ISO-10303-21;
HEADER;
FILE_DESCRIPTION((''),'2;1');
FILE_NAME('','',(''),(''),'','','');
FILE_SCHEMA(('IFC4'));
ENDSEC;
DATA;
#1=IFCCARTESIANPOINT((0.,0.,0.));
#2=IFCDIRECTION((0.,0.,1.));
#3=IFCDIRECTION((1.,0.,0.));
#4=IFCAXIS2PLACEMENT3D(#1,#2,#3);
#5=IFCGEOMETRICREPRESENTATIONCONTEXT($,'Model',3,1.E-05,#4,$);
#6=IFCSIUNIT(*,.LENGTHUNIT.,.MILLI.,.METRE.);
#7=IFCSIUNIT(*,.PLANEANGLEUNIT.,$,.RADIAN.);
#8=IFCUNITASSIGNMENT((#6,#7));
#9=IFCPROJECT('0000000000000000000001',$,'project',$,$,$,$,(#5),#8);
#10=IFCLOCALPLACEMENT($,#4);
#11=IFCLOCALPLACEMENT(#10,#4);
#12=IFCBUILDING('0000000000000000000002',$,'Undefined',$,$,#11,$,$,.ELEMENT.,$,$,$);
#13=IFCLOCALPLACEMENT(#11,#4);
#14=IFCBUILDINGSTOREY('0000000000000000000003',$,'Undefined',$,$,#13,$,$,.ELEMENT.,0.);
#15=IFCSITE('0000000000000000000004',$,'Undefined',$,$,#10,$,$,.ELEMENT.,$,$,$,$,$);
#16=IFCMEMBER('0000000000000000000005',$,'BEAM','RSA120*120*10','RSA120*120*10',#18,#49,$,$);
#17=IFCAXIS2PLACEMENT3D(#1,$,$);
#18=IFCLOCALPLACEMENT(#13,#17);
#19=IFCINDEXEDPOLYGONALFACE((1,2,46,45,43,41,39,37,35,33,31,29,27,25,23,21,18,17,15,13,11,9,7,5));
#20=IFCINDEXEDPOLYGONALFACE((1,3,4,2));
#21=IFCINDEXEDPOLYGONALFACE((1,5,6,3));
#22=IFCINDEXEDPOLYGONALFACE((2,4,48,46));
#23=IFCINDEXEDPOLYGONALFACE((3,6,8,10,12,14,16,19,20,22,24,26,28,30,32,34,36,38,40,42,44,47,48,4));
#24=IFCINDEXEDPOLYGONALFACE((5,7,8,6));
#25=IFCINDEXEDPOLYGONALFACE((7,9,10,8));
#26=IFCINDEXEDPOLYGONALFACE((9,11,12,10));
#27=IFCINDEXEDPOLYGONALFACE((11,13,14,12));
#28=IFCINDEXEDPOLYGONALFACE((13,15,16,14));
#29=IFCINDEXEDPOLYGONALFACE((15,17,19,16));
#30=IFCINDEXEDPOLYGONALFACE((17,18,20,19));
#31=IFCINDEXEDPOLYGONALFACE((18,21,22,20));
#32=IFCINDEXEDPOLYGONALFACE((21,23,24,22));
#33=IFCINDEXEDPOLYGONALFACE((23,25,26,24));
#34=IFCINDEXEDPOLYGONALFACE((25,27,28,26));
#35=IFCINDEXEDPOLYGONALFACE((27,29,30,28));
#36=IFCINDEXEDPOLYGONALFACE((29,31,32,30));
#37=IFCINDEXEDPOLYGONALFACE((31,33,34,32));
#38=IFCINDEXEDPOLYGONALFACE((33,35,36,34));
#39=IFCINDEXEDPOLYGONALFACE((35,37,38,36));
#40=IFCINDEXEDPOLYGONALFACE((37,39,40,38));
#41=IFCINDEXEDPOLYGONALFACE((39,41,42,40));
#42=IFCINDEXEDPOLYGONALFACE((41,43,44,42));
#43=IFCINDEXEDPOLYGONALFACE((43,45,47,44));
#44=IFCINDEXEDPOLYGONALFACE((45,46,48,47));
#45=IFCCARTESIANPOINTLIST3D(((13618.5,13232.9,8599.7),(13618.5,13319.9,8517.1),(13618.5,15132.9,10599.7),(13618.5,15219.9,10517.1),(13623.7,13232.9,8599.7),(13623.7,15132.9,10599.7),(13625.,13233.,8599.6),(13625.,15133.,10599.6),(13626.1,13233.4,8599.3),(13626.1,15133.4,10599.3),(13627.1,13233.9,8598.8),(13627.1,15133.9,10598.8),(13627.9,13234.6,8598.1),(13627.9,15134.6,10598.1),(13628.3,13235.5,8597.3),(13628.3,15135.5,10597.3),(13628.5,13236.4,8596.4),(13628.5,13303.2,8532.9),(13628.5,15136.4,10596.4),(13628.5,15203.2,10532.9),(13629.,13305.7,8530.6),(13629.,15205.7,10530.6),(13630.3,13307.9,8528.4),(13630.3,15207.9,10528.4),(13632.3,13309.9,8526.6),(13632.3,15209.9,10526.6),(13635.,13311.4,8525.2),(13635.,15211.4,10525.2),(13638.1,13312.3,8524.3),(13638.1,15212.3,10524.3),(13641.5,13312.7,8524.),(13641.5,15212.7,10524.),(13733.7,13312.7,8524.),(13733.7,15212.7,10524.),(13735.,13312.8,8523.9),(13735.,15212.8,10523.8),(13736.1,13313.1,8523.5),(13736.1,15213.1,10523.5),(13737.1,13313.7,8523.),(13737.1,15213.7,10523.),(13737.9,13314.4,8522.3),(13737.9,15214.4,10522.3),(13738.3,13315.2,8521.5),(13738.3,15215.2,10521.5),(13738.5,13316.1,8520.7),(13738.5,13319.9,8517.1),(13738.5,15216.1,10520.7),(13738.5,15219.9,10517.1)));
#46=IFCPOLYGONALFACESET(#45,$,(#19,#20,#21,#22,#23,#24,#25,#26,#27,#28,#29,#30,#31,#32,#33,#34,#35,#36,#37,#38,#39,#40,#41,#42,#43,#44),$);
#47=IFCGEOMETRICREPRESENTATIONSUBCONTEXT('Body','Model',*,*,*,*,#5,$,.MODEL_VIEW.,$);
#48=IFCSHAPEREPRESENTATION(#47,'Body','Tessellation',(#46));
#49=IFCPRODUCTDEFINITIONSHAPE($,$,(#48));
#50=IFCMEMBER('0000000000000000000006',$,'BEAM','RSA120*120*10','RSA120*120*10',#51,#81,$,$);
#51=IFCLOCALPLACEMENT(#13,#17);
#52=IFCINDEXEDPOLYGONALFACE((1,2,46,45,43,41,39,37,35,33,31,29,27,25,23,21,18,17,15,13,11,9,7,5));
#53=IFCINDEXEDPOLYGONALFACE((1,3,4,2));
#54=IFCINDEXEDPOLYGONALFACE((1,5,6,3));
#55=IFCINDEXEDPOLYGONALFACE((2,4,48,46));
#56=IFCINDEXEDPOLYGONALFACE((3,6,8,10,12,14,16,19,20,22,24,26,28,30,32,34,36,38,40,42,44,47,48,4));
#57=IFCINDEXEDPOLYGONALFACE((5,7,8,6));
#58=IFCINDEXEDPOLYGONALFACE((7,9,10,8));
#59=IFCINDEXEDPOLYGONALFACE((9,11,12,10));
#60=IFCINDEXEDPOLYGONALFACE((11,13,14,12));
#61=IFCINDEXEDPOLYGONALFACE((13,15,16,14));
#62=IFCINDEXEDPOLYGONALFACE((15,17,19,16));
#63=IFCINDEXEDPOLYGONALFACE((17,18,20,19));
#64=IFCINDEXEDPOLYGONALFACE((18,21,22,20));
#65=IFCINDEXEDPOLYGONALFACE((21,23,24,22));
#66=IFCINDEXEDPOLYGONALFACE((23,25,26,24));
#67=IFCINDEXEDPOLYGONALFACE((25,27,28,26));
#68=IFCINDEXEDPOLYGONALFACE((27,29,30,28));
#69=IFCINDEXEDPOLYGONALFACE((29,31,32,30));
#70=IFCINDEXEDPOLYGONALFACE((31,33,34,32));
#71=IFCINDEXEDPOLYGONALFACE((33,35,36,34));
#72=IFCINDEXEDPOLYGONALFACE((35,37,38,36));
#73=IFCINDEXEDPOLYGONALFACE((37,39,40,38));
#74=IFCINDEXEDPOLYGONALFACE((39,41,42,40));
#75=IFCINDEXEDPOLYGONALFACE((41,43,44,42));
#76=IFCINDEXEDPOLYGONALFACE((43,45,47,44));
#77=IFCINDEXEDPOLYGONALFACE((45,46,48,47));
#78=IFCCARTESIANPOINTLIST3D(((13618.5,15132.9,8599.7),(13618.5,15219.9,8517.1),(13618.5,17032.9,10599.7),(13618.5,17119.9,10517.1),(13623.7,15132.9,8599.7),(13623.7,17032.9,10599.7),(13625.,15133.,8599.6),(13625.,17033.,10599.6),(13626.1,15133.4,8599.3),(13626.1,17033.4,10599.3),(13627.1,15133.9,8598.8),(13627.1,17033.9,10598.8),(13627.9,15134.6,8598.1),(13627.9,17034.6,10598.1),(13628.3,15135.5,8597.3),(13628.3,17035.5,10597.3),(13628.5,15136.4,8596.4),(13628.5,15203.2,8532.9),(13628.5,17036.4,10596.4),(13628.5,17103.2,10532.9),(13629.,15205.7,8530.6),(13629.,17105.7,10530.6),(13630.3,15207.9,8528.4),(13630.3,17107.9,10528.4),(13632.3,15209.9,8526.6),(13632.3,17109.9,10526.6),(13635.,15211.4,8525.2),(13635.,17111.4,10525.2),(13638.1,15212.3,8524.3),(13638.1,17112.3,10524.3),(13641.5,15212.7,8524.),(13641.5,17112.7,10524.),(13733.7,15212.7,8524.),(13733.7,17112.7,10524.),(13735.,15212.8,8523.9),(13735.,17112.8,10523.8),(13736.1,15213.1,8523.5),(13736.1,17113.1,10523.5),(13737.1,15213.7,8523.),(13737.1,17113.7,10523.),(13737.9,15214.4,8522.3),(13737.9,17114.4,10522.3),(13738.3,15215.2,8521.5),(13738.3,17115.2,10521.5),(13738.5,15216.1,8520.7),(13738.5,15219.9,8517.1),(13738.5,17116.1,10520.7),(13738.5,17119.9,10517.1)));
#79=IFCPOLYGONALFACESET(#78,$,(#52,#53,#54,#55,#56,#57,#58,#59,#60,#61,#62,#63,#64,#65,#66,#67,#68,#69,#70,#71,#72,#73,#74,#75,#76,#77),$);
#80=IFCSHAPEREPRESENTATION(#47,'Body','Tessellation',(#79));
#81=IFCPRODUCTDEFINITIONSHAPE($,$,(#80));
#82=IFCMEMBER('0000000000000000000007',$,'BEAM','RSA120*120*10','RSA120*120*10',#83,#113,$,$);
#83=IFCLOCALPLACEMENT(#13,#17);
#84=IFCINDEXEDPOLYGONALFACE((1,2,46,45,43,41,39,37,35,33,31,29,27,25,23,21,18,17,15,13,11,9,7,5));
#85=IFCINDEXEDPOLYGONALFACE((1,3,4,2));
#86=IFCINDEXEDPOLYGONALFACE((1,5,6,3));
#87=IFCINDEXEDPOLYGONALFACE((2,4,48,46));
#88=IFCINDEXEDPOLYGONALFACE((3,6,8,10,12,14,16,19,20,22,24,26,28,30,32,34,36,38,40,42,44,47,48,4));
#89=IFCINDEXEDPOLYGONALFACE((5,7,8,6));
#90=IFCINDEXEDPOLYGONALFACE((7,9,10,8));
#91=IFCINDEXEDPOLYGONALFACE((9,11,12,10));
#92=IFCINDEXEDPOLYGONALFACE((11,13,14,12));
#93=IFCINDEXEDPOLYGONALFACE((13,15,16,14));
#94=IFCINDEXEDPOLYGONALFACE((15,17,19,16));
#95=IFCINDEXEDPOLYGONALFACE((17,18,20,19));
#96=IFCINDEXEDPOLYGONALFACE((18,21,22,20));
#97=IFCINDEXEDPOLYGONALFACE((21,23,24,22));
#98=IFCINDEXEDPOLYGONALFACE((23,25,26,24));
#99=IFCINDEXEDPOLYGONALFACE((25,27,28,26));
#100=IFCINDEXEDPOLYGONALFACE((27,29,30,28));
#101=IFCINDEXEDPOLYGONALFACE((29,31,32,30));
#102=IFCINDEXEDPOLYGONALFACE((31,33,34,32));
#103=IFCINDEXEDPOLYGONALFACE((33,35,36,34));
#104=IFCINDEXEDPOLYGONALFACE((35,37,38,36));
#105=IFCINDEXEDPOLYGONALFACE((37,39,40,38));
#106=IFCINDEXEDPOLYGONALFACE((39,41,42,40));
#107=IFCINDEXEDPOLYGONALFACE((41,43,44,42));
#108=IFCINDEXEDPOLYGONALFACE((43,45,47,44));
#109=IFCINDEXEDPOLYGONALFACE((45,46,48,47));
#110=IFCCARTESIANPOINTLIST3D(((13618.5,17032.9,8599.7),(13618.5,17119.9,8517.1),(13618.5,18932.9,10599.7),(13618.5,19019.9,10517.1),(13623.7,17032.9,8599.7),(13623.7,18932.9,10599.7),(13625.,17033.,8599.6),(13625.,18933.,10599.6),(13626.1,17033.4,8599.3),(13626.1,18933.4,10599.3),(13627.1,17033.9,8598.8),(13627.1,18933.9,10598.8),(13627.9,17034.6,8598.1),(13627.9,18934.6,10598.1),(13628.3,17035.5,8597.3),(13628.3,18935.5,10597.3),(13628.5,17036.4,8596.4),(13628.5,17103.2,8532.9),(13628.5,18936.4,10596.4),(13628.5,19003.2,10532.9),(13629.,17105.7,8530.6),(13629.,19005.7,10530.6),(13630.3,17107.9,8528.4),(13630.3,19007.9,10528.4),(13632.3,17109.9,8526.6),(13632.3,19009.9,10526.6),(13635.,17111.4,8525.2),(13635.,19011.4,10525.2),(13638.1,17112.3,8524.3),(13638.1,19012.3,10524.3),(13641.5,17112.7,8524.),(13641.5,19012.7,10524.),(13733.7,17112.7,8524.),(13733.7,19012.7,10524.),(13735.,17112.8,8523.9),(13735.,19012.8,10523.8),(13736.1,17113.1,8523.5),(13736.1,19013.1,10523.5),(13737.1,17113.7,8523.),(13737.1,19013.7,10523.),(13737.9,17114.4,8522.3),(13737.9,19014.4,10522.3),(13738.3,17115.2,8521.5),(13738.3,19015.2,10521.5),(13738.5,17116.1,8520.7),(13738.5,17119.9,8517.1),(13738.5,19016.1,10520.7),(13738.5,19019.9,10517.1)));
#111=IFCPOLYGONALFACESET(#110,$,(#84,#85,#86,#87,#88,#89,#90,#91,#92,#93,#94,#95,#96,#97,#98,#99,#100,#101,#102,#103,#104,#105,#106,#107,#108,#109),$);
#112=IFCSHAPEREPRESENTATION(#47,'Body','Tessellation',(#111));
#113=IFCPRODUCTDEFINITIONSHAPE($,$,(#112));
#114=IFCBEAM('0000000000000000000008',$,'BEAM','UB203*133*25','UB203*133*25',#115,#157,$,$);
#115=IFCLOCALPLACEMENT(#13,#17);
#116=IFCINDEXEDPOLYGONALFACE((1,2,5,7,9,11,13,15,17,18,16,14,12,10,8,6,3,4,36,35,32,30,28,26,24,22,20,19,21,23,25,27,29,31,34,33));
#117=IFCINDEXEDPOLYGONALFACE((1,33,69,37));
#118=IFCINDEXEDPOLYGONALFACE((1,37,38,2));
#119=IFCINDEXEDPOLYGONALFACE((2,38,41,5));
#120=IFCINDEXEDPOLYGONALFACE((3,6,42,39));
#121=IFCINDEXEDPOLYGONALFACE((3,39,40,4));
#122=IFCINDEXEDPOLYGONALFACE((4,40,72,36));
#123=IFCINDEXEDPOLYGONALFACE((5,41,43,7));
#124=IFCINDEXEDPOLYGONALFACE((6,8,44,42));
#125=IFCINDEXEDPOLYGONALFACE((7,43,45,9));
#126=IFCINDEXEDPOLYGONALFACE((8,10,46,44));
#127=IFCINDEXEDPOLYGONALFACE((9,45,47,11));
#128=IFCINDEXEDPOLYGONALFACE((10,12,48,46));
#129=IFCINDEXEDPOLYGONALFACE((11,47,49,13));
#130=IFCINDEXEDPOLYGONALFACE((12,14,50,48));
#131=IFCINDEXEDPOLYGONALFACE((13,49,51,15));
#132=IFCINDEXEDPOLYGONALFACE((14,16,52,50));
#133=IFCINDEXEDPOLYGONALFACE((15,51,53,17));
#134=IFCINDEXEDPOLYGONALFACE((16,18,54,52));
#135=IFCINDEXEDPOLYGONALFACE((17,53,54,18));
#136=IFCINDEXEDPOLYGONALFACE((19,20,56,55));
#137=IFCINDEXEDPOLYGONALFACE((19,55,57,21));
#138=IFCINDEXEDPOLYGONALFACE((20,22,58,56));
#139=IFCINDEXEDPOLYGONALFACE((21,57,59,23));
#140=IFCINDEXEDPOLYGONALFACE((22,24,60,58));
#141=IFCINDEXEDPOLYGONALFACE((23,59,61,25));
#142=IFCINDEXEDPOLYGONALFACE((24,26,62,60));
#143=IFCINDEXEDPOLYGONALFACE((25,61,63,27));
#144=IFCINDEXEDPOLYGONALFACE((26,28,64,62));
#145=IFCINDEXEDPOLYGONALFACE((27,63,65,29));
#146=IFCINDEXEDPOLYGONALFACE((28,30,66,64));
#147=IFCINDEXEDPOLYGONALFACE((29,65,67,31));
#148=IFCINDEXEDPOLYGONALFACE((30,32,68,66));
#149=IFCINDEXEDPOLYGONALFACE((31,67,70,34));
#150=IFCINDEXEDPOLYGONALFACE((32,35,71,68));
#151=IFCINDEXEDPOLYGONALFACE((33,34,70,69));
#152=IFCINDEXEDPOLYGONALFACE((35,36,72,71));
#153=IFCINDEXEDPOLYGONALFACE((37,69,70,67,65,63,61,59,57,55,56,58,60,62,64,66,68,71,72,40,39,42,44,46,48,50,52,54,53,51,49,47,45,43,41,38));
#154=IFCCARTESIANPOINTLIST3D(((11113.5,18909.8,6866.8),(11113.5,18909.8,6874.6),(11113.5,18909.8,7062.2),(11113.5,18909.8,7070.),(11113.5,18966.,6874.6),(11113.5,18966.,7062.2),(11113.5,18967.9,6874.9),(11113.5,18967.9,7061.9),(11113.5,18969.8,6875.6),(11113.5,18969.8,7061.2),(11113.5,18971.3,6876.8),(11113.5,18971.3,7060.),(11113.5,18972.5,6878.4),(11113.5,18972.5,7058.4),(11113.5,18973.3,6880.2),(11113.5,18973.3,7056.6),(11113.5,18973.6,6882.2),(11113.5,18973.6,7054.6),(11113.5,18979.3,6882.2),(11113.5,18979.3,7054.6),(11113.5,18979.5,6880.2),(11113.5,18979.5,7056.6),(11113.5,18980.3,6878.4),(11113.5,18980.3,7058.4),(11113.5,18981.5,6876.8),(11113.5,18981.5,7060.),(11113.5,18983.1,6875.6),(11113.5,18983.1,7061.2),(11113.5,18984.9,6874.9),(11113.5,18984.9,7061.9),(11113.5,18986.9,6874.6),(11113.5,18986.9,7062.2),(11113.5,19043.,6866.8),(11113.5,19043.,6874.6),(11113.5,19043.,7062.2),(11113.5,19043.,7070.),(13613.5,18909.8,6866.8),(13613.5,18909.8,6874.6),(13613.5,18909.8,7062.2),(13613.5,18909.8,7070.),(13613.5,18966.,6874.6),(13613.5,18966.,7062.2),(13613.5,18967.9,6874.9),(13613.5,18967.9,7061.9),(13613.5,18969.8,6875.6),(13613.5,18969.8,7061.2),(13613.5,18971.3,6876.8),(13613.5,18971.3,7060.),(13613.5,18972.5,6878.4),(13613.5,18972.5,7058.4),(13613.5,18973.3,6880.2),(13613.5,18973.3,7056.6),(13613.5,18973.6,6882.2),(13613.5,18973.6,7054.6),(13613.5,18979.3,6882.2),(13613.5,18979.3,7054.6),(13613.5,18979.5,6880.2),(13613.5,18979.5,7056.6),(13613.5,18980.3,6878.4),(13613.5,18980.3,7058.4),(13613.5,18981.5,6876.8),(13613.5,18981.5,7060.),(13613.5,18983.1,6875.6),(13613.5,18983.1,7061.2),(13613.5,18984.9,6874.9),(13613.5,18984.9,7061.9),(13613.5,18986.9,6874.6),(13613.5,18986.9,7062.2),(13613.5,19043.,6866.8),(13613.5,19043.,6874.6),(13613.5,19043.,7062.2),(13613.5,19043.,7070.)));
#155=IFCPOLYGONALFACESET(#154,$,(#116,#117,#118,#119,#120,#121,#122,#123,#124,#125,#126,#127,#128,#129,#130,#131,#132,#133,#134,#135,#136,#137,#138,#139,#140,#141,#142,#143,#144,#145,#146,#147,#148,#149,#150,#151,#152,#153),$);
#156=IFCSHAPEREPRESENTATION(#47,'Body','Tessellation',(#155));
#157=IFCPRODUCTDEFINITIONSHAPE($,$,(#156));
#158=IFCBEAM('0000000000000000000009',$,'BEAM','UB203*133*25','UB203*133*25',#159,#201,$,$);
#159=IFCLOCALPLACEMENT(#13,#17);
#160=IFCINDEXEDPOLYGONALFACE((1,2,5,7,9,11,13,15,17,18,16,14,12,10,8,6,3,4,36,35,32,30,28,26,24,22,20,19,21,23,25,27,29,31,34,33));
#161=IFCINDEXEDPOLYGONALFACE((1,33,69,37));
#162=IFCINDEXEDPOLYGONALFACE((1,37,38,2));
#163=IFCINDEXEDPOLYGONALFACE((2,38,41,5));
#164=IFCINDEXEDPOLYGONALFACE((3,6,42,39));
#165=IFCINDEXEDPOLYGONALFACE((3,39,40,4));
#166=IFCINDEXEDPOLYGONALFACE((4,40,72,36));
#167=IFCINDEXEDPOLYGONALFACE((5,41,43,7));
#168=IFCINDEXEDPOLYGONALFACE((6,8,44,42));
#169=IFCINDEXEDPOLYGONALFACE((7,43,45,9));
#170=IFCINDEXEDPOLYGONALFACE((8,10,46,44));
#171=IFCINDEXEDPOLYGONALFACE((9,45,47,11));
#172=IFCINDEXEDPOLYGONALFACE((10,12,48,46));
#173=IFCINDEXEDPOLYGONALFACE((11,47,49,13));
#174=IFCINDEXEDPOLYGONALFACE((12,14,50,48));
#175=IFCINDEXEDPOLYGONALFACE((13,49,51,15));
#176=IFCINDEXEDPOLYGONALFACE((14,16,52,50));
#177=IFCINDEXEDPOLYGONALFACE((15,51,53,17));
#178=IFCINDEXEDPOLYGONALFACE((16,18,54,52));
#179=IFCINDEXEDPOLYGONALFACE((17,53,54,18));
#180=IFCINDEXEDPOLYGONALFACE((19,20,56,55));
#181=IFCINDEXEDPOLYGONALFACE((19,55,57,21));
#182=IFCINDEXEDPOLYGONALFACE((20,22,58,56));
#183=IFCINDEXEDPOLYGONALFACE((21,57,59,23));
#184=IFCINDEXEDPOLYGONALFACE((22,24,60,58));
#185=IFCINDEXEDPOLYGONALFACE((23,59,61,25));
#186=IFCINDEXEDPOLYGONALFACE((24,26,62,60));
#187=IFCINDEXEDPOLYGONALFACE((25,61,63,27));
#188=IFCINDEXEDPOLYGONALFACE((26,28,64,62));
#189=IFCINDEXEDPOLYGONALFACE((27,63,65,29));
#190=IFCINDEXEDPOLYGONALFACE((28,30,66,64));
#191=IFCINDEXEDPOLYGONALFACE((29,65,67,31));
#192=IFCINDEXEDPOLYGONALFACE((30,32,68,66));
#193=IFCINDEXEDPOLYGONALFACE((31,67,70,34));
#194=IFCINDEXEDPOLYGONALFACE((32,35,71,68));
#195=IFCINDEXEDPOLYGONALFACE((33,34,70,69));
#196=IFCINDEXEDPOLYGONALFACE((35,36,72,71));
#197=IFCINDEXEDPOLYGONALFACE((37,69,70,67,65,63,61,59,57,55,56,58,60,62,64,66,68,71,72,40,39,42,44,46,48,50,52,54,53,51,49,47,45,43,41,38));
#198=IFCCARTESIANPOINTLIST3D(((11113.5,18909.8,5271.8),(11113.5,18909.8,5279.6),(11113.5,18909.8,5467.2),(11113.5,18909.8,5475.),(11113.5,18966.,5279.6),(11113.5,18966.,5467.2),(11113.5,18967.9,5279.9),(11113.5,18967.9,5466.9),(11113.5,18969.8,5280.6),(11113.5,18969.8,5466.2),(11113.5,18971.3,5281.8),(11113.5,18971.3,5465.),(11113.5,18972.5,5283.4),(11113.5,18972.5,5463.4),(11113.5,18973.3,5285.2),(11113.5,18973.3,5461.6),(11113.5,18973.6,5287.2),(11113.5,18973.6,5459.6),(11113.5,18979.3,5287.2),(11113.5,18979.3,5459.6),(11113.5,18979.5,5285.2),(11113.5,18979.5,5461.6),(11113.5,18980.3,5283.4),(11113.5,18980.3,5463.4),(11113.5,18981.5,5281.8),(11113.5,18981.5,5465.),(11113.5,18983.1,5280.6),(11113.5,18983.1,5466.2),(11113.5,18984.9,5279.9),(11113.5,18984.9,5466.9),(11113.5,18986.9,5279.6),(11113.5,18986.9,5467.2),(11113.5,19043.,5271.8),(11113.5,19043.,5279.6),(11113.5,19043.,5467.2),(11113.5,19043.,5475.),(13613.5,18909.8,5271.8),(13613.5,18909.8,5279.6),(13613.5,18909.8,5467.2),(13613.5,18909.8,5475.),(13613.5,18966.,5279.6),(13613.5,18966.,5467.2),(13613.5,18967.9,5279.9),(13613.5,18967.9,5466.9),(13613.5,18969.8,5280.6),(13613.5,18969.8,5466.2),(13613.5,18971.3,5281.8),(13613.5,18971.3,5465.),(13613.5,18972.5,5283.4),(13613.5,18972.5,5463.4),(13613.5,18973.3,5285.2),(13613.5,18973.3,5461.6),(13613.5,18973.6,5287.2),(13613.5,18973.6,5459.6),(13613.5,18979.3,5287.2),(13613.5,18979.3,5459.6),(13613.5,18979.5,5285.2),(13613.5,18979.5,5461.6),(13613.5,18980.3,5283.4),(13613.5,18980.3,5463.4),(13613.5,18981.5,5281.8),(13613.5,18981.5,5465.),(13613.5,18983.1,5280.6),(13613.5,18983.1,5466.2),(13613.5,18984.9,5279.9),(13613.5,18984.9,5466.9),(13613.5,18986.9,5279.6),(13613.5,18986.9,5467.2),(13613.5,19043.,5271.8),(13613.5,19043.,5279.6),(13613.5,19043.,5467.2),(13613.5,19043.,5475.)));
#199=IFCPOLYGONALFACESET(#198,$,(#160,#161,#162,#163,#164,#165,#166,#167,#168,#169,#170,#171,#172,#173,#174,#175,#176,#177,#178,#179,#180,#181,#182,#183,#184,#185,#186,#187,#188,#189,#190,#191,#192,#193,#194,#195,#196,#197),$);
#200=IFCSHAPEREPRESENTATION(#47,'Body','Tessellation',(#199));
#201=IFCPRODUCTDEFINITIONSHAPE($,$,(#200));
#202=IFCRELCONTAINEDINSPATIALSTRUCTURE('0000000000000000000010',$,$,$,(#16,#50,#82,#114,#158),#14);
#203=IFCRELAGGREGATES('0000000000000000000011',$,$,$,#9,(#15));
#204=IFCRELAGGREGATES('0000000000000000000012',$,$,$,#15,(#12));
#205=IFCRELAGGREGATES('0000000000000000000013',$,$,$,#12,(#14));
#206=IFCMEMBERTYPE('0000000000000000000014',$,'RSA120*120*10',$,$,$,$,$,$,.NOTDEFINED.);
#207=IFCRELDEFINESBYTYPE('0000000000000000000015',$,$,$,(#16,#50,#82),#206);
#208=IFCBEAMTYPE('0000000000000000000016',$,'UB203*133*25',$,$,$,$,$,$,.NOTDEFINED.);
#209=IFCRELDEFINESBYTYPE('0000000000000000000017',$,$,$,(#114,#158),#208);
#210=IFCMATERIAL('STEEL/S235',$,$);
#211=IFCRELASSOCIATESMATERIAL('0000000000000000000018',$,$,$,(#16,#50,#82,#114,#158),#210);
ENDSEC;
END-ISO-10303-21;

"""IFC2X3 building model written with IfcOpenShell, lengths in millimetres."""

from ifc_helpers import new_model, si_unit, frame, origin_with_axes, origin_2d_with_axis, place, context, subcontext, project, spatial, i_section, l_section, extrude, material, type_object, element, save


model = new_model("IFC2X3")

# Units and contexts
model_context = context("Model", 3, precision=1e-05, world=origin_with_axes())
body_context = subcontext(model_context, "Body", "Model", "MODEL_VIEW")
ifc_project = project(units=[si_unit("LENGTHUNIT", "METRE", prefix="MILLI"), si_unit("PLANEANGLEUNIT", "RADIAN")], contexts=[model_context])

# Site, building, storey
site_placement = place(None, origin_with_axes())
site = spatial("IfcSite", under=ifc_project, at=site_placement, Name="Undefined", CompositionType="ELEMENT")
building_placement = place(site_placement, origin_with_axes())
building = spatial("IfcBuilding", under=site, at=building_placement, Name="Undefined", CompositionType="ELEMENT")
storey_placement = place(building_placement, origin_with_axes())
storey = spatial("IfcBuildingStorey", under=building, at=storey_placement, Name="Undefined", CompositionType="ELEMENT", Elevation=0.0)

# Shared definitions
ifc_material = material(Name="STEEL/S235")

# Members
member_type_1 = type_object("IfcMemberType", Name="RSA120*120*10", PredefinedType="NOTDEFINED")
for number, where, z_axis, x_axis, name in (
    (1, (13678.5, 13276.4, 8558.4), (0.0, -0.724999, 0.688749), (0.0, 0.688749, 0.724999), "BEAM"),
    (2, (13678.5, 15176.4, 8558.4), (0.0, -0.724999, 0.688749), (0.0, 0.688749, 0.724999), "BEAM"),
    (3, (13678.5, 17076.4, 8558.4), (0.0, -0.724999, 0.688749), (0.0, 0.688749, 0.724999), "BEAM"),
):
    element("IfcMember", number, at=place(storey_placement, frame(where, z_axis=z_axis, x_axis=x_axis)), inside=storey, type_object=member_type_1, material=ifc_material, Name=name, Description="RSA120*120*10", ObjectType="RSA120*120*10", context=body_context, shape_type="SweptSolid", body=[
        extrude(l_section(Depth=120.0, Width=120.0, Thickness=10.0, FilletRadius=13.0, EdgeRadius=4.8, at=origin_2d_with_axis()), frame((2758.6, 0.0, 0.0), z_axis=(-1.0, 0.0, 0.0), x_axis=(0.0, -1.0, 0.0)), (0.0, 0.0, 1.0), 2758.6),
    ])

# Beams
beam_type_1 = type_object("IfcBeamType", Name="UB203*133*25", PredefinedType="NOTDEFINED")
for number, where, z_axis, x_axis, name in (
    (4, (11113.5, 18976.4, 6968.4), (0.0, 0.0, 1.0), (1.0, 0.0, 0.0), "BEAM"),
    (5, (11113.5, 18976.4, 5373.4), (0.0, 0.0, 1.0), (1.0, 0.0, 0.0), "BEAM"),
):
    element("IfcBeam", number, at=place(storey_placement, frame(where, z_axis=z_axis, x_axis=x_axis)), inside=storey, type_object=beam_type_1, material=ifc_material, Name=name, Description="UB203*133*25", ObjectType="UB203*133*25", context=body_context, shape_type="SweptSolid", body=[
        extrude(i_section(OverallWidth=133.2, OverallDepth=203.2, WebThickness=5.7, FlangeThickness=7.8, FilletRadius=7.6, at=origin_2d_with_axis()), frame((2500.0, 0.0, 0.0), z_axis=(-1.0, 0.0, 0.0), x_axis=(0.0, -1.0, 0.0)), (0.0, 0.0, 1.0), 2500.0),
    ])

save(model, "model.ifc")
